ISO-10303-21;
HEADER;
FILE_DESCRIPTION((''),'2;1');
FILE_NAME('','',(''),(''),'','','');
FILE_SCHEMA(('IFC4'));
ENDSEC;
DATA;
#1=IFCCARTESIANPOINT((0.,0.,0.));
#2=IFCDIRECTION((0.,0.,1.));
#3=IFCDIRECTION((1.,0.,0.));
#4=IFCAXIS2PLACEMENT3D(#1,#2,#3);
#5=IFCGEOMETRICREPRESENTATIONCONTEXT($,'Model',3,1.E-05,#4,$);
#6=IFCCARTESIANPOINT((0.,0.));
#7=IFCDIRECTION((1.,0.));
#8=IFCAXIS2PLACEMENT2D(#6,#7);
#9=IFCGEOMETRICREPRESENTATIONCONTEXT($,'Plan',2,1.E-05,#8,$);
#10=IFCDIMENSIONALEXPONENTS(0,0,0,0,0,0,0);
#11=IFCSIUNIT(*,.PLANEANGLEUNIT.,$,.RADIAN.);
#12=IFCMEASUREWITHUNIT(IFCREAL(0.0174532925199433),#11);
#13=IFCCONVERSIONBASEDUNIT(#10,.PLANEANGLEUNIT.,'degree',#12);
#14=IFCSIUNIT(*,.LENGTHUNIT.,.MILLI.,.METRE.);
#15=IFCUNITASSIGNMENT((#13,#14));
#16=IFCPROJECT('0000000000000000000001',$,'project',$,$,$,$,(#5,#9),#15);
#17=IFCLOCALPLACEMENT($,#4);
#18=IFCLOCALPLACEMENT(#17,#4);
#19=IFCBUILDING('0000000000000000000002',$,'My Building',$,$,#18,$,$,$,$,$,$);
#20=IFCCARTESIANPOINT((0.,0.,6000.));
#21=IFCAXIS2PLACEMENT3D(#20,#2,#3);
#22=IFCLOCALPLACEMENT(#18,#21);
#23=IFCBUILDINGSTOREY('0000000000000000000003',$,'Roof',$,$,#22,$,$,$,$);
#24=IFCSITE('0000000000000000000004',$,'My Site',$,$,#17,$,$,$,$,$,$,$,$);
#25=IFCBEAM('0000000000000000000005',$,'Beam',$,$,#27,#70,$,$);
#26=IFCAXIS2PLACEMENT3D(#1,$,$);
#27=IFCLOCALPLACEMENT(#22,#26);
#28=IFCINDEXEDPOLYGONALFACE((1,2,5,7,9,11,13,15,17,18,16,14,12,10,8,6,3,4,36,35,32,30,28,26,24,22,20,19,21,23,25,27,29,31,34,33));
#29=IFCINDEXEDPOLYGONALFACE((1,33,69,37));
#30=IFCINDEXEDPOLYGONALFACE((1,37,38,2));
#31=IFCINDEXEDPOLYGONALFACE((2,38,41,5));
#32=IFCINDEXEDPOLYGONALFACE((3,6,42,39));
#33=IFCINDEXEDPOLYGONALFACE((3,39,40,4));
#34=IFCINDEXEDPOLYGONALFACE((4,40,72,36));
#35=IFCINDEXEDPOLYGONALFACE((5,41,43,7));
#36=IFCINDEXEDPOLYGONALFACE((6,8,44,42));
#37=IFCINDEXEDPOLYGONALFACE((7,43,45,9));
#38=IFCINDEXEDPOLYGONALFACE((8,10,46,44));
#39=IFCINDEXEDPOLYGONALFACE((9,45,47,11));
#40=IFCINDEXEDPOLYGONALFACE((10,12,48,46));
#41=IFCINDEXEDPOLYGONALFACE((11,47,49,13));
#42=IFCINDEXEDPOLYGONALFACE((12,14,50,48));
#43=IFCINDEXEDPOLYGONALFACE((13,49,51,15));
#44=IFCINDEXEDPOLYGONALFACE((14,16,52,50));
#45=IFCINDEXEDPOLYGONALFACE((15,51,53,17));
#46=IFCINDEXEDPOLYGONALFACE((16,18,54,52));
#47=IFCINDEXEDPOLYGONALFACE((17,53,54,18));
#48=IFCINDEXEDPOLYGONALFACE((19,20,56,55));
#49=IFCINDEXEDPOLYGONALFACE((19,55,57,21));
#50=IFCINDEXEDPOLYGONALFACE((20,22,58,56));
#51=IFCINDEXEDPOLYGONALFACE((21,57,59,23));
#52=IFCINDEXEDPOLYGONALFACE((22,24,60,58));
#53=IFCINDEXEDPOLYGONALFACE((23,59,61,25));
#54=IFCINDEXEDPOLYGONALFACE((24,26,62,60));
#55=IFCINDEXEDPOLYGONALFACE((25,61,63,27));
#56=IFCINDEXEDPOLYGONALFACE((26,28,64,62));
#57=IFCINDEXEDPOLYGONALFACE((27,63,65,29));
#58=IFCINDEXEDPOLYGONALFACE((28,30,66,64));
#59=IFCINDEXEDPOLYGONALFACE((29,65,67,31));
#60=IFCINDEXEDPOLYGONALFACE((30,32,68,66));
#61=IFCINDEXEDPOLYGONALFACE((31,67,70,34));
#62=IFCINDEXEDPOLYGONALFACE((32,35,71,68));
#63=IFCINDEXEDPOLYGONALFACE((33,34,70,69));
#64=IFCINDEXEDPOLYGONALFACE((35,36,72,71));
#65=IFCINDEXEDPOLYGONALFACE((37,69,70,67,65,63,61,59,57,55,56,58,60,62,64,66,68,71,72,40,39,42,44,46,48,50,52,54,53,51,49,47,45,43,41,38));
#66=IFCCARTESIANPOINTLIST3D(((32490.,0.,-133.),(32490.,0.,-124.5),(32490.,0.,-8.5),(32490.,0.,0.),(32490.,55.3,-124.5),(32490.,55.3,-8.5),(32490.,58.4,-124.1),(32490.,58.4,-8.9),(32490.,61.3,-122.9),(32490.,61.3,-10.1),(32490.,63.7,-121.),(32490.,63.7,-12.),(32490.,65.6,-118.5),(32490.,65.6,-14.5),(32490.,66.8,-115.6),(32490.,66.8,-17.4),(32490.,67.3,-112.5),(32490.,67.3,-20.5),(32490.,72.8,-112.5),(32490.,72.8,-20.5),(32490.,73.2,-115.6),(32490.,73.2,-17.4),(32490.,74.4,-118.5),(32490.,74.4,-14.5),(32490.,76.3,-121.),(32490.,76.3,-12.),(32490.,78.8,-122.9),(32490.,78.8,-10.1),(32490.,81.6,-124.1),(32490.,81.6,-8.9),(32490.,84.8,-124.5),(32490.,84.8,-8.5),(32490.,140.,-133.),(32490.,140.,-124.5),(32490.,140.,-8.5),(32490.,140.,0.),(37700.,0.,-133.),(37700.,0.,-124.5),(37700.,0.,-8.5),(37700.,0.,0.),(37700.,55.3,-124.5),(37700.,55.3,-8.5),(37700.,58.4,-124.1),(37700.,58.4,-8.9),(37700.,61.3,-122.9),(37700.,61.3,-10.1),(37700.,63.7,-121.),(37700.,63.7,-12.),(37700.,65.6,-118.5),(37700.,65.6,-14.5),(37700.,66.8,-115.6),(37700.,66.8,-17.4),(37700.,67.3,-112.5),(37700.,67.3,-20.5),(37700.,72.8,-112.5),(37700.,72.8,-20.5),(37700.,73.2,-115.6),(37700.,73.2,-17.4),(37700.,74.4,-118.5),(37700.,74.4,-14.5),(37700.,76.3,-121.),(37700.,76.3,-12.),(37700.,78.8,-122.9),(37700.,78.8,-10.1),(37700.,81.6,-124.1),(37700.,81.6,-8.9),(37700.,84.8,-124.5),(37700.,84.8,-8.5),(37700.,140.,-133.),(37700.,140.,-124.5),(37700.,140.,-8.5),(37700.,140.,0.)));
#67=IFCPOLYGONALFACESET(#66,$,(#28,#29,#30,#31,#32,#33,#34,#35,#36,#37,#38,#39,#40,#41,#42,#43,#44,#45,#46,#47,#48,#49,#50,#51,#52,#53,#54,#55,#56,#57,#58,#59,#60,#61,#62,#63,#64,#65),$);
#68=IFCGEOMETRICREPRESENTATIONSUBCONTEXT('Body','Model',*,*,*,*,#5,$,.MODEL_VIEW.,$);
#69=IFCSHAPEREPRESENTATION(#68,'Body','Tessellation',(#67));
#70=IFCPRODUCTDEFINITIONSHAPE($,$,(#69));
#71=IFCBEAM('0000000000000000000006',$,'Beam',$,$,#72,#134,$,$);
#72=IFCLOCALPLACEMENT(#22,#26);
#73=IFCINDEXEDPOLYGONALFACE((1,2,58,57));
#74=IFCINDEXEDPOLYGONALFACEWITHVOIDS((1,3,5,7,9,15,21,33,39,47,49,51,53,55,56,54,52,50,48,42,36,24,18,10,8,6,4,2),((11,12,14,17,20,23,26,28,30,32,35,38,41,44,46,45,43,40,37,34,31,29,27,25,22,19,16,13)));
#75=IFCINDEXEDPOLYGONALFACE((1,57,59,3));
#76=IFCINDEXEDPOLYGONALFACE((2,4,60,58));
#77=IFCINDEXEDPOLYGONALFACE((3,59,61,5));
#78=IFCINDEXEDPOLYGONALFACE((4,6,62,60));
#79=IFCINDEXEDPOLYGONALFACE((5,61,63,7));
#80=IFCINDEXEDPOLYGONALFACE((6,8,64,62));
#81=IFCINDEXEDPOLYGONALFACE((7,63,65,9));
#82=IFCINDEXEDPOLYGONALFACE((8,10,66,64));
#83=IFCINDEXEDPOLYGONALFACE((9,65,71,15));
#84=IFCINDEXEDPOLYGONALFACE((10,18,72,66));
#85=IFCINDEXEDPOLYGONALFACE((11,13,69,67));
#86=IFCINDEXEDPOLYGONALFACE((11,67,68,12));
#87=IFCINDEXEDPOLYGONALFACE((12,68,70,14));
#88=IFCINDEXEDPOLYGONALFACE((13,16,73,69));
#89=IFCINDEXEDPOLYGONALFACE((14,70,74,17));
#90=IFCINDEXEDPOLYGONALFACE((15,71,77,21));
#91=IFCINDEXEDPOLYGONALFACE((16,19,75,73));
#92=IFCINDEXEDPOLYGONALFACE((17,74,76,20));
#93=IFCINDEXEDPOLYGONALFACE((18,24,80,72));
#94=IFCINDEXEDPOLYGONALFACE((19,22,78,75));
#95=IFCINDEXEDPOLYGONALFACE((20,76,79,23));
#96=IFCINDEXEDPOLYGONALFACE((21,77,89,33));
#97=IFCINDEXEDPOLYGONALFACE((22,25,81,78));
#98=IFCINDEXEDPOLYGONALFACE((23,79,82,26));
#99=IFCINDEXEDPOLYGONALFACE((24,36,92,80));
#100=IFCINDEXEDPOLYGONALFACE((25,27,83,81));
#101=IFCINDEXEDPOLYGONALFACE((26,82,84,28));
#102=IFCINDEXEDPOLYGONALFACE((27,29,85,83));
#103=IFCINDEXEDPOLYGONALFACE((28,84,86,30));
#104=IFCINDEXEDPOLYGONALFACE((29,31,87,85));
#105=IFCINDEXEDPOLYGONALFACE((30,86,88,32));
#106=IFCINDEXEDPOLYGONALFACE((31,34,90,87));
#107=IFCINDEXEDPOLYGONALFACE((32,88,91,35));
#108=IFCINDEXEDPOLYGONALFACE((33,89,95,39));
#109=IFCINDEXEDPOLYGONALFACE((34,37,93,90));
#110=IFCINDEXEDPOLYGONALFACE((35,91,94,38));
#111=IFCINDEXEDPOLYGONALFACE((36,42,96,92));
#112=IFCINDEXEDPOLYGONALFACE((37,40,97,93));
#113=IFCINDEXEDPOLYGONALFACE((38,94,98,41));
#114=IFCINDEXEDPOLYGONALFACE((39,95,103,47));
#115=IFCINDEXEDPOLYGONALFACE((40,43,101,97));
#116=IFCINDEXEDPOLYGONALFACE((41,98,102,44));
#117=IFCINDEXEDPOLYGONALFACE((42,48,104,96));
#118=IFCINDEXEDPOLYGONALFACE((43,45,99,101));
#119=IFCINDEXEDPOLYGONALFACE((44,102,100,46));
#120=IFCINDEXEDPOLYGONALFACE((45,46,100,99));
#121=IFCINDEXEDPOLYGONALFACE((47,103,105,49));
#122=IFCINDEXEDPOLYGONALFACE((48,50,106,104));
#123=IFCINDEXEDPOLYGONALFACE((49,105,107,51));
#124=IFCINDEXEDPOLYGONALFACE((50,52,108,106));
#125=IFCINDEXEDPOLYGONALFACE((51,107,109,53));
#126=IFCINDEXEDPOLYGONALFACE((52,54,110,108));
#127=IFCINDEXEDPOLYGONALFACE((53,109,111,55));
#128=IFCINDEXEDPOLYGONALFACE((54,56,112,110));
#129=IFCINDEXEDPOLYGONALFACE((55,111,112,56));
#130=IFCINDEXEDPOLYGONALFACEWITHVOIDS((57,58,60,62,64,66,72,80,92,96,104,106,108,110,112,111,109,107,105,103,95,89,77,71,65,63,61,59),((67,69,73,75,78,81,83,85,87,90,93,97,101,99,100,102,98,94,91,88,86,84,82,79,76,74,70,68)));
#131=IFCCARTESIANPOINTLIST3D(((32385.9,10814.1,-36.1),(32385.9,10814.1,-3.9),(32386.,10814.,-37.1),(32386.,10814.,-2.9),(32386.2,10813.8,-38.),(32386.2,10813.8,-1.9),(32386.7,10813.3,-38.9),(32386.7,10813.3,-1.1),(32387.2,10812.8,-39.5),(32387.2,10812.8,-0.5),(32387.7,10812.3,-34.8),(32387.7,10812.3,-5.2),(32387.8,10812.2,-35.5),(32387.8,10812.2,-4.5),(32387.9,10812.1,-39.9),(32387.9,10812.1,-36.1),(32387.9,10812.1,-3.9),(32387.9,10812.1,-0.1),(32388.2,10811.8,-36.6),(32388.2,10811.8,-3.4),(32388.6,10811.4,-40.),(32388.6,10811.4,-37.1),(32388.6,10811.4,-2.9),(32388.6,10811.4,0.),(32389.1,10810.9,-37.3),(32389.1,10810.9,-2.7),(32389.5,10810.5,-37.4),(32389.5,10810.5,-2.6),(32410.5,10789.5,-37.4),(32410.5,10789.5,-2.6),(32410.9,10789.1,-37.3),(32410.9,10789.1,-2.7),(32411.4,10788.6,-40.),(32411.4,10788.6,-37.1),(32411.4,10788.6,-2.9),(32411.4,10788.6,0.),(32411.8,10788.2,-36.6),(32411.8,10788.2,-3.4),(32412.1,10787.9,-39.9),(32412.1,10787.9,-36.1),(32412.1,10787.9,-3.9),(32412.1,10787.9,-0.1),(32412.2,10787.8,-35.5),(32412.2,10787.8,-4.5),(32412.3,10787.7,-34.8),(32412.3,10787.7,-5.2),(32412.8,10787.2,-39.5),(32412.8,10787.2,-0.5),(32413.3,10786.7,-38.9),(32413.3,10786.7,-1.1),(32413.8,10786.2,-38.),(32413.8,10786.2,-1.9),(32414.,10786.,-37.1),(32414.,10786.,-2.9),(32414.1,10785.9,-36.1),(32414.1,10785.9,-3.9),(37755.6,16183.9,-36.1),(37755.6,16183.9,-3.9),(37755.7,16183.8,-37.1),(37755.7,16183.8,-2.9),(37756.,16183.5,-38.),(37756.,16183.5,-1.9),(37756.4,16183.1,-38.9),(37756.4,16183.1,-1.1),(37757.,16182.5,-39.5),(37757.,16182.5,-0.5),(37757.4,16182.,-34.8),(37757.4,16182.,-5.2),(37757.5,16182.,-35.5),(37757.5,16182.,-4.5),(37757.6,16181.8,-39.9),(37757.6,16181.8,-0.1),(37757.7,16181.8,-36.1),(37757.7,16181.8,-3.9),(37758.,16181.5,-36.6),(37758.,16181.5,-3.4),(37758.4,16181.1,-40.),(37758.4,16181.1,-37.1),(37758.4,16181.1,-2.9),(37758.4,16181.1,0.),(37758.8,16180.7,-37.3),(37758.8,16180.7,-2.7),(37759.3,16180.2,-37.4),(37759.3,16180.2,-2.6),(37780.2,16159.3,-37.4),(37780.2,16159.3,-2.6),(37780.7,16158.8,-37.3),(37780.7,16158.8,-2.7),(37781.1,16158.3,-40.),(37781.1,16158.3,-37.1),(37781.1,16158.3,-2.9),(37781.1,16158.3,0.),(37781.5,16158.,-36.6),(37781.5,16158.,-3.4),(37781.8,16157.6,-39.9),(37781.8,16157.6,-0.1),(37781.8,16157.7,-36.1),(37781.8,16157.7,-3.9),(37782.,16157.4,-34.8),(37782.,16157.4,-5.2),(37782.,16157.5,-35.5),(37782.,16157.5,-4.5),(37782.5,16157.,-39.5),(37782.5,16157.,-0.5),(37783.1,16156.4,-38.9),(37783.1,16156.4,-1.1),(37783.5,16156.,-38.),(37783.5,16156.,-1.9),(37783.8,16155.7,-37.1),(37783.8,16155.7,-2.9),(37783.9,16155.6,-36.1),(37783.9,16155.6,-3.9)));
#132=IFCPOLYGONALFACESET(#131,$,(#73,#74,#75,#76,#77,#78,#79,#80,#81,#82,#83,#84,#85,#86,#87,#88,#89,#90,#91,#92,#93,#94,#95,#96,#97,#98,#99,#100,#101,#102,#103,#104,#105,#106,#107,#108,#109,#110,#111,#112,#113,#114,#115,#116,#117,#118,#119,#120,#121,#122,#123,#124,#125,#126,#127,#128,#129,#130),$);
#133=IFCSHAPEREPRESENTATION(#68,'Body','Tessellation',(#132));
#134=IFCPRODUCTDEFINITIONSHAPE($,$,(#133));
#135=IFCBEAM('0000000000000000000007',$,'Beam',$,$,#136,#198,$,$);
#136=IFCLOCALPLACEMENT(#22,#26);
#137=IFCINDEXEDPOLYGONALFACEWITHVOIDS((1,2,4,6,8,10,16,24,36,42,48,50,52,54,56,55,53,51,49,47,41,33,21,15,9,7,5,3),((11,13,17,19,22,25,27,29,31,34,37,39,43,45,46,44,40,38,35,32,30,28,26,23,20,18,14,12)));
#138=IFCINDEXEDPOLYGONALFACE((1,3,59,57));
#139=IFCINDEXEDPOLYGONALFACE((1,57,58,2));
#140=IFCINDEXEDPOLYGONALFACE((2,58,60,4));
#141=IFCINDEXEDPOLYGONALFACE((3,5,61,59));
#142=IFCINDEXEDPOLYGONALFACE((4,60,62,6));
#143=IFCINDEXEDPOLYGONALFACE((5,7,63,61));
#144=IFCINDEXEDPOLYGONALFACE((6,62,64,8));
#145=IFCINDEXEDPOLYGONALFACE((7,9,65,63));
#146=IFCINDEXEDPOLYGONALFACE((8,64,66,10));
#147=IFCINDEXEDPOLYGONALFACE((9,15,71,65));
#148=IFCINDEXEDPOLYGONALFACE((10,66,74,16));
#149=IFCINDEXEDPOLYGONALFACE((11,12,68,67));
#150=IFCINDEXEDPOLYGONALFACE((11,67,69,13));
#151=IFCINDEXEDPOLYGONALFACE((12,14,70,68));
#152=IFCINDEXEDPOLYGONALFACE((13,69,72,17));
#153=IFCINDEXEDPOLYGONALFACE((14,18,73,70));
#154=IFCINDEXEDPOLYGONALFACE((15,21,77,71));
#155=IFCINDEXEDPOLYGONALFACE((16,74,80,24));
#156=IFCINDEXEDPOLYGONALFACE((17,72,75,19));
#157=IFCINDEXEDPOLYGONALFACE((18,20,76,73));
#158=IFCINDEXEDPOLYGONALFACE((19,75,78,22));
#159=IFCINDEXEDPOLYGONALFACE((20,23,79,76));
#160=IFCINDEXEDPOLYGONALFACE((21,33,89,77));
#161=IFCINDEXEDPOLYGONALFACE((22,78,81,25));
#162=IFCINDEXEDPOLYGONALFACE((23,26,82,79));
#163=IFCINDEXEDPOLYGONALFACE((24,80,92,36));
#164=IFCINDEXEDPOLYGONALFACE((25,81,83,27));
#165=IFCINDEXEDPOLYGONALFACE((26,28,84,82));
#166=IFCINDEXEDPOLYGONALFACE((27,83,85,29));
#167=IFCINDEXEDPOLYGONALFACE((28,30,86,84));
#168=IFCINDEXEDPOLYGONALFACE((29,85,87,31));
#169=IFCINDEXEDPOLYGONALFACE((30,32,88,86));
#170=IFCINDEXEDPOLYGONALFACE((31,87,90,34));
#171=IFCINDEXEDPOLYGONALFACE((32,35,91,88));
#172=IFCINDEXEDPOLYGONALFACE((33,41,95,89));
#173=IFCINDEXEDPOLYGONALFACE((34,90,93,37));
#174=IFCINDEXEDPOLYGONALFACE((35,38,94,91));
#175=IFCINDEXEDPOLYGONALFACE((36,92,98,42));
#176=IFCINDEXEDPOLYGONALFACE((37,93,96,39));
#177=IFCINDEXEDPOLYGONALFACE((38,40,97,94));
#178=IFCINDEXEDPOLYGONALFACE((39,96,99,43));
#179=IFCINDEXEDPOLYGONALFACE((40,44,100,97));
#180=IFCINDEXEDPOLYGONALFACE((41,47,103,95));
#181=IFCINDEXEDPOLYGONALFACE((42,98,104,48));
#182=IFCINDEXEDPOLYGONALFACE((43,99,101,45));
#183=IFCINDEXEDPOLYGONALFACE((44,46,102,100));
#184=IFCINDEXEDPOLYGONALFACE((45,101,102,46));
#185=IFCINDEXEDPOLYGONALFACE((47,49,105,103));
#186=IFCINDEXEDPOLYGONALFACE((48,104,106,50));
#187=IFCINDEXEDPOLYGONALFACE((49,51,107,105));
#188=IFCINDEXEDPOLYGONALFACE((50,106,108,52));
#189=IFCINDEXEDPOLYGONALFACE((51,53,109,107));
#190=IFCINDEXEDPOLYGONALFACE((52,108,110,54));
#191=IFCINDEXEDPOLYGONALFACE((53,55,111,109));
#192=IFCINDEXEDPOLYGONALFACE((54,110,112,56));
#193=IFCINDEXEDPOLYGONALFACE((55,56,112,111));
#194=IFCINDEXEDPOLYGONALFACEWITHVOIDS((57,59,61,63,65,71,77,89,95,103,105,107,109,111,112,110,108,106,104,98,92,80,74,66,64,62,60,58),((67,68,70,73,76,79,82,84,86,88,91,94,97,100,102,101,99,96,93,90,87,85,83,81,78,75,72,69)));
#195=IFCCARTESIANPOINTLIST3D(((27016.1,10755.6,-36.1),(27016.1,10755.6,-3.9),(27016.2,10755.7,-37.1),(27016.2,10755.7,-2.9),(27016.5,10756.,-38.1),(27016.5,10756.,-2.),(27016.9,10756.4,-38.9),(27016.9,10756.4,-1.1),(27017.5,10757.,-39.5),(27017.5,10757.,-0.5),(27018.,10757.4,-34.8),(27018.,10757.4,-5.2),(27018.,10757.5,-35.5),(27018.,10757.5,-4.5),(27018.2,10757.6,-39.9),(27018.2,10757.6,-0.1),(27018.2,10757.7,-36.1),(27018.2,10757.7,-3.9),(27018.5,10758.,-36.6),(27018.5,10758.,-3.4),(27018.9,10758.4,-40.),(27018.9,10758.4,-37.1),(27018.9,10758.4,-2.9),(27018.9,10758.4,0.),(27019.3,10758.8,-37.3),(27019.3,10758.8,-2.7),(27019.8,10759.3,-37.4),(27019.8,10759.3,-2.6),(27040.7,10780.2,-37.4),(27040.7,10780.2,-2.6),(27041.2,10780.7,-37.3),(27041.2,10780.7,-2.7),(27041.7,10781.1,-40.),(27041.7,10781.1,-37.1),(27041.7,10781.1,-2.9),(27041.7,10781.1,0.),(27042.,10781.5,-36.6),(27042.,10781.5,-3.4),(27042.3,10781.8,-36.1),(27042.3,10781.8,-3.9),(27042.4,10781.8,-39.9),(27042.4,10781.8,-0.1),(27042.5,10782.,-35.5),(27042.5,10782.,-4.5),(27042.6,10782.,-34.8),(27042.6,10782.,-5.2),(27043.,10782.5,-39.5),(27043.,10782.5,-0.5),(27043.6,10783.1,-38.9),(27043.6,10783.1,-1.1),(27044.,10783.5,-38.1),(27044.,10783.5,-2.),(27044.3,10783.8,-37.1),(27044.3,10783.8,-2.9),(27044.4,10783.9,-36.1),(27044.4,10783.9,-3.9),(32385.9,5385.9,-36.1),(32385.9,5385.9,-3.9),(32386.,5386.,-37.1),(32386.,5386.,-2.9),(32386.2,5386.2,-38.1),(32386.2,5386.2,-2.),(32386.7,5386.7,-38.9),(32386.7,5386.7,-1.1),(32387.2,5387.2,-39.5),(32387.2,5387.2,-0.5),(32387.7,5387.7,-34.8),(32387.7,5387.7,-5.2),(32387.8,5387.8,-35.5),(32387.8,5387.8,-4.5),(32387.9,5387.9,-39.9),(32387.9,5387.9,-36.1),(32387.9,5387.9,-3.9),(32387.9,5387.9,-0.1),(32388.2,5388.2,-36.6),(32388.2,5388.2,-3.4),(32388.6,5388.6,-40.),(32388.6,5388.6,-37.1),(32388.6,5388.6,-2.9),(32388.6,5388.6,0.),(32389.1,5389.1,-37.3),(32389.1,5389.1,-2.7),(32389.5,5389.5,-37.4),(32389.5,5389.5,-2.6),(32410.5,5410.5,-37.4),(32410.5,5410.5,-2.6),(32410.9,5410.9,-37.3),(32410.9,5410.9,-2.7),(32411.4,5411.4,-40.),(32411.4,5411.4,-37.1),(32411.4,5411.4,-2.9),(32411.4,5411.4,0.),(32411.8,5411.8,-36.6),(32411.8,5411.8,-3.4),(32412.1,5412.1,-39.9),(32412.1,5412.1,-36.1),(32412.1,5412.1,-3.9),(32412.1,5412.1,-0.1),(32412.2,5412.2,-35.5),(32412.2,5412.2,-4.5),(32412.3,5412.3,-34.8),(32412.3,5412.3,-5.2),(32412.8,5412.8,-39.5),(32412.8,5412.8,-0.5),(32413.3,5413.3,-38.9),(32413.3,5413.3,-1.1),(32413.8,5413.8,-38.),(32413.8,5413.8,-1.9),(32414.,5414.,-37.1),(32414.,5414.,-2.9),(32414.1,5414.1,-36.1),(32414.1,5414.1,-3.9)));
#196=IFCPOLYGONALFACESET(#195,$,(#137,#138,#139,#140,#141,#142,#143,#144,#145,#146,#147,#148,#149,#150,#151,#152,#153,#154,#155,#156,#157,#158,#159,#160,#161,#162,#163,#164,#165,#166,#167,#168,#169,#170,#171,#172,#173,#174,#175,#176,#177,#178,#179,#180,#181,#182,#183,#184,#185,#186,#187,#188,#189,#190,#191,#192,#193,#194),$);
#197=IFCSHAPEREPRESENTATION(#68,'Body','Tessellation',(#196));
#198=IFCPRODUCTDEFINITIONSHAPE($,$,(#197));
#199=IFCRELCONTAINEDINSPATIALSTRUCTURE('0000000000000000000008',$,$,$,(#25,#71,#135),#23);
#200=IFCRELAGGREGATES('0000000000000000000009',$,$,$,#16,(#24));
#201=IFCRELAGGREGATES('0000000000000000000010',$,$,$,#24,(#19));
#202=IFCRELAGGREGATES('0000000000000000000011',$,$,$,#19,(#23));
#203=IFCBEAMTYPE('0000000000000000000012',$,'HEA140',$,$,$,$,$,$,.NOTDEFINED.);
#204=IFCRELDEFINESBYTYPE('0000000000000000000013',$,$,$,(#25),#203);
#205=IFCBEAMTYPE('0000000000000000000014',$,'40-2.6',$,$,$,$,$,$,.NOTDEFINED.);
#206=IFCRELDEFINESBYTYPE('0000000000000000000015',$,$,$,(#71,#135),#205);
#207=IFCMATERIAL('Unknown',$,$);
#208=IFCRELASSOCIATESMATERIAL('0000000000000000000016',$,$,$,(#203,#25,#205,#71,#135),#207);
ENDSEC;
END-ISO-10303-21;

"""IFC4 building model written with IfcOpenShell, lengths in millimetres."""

from ifc_helpers import new_model, entity, si_unit, converted_unit, frame, origin_with_axes, origin_2d_with_axis, place, context, subcontext, project, spatial, hollow_rectangle, i_section, extrude, material, material_profile, profile_set, profile_usage, type_object, element, save


model = new_model("IFC4")

# Units and contexts
model_context = context("Model", 3, precision=1e-05, world=origin_with_axes())
plan_context = context("Plan", 2, precision=1e-05, world=origin_2d_with_axis())
body_context = subcontext(model_context, "Body", "Model", "MODEL_VIEW")
ifc_project = project(units=[converted_unit("PLANEANGLEUNIT", "degree", entity("IfcReal", 0.0174532925199433), si_unit("PLANEANGLEUNIT", "RADIAN"), dimensions=[0, 0, 0, 0, 0, 0, 0]), si_unit("LENGTHUNIT", "METRE", prefix="MILLI")], contexts=[model_context, plan_context])

# Site, building, storey
site_placement = place(None, origin_with_axes())
site = spatial("IfcSite", under=ifc_project, at=site_placement, Name="My Site")
building_placement = place(site_placement, origin_with_axes())
building = spatial("IfcBuilding", under=site, at=building_placement, Name="My Building")
storey_placement = place(building_placement, frame((0.0, 0.0, 6000.0), z_axis=(0.0, 0.0, 1.0), x_axis=(1.0, 0.0, 0.0)))
storey = spatial("IfcBuildingStorey", under=building, at=storey_placement, Name="Roof")

# Beams
ifc_material = material(Name="Unknown")
ifc_material_profile_1 = material_profile(ifc_material, i_section(OverallWidth=140.0, OverallDepth=133.0, WebThickness=5.5, FlangeThickness=8.5, FilletRadius=12.0))
ifc_profile_set_1 = profile_set([ifc_material_profile_1])
beam_type_1 = type_object("IfcBeamType", Name="HEA140", PredefinedType="NOTDEFINED", material=ifc_profile_set_1)
ifc_profile_usage_1 = profile_usage(ifc_profile_set_1, cardinal=7)
beam_1_placement = place(storey_placement, frame((37700.0, 0.0, 0.0), z_axis=(-1.0, 0.0, 0.0), x_axis=(0.0, -1.0, 0.0)))
element("IfcBeam", 1, at=beam_1_placement, inside=storey, type_object=beam_type_1, material=ifc_profile_usage_1, Name="Beam", context=body_context, shape_type="SweptSolid", body=[
    extrude(i_section(OverallWidth=140.0, OverallDepth=133.0, WebThickness=5.5, FlangeThickness=8.5, FilletRadius=12.0), frame((-70.0, -66.5, 0.0), z_axis=(0.0, 0.0, 1.0), x_axis=(1.0, 0.0, 0.0)), (0.0, 0.0, 1.0), 5210.0),
])
ifc_material_profile_2 = material_profile(ifc_material, hollow_rectangle(XDim=40.0, YDim=40.0, WallThickness=2.6, InnerFilletRadius=2.6, OuterFilletRadius=3.9))
ifc_profile_set_2 = profile_set([ifc_material_profile_2])
ifc_profile_usage_2 = profile_usage(ifc_profile_set_2, cardinal=8)
beam_type_2 = type_object("IfcBeamType", Name="40-2.6", PredefinedType="NOTDEFINED", material=ifc_profile_set_2)
beam_2_placement = place(storey_placement, frame((32400.0, 10800.0, 0.0), z_axis=(0.707107, 0.707107, 0.0), x_axis=(-0.707107, 0.707107, 0.0)))
element("IfcBeam", 2, at=beam_2_placement, inside=storey, type_object=beam_type_2, material=ifc_profile_usage_2, Name="Beam", context=body_context, shape_type="SweptSolid", body=[
    extrude(hollow_rectangle(XDim=40.0, YDim=40.0, WallThickness=2.6, InnerFilletRadius=2.6, OuterFilletRadius=3.9), frame((0.0, -20.0, 0.0), z_axis=(0.0, 0.0, 1.0), x_axis=(1.0, 0.0, 0.0)), (0.0, 0.0, 1.0), 7594.0),
])
ifc_profile_usage_3 = profile_usage(ifc_profile_set_2, cardinal=8)
beam_3_placement = place(storey_placement, frame((32400.0, 5400.0, 0.0), z_axis=(-0.707107, 0.707107, 0.0), x_axis=(-0.707107, -0.707107, 0.0)))
element("IfcBeam", 3, at=beam_3_placement, inside=storey, type_object=beam_type_2, material=ifc_profile_usage_3, Name="Beam", context=body_context, shape_type="SweptSolid", body=[
    extrude(hollow_rectangle(XDim=40.0, YDim=40.0, WallThickness=2.6, InnerFilletRadius=2.6, OuterFilletRadius=3.9), frame((0.0, -20.0, 0.0), z_axis=(0.0, 0.0, 1.0), x_axis=(1.0, 0.0, 0.0)), (0.0, 0.0, 1.0), 7594.0),
])

save(model, "model.ifc")
